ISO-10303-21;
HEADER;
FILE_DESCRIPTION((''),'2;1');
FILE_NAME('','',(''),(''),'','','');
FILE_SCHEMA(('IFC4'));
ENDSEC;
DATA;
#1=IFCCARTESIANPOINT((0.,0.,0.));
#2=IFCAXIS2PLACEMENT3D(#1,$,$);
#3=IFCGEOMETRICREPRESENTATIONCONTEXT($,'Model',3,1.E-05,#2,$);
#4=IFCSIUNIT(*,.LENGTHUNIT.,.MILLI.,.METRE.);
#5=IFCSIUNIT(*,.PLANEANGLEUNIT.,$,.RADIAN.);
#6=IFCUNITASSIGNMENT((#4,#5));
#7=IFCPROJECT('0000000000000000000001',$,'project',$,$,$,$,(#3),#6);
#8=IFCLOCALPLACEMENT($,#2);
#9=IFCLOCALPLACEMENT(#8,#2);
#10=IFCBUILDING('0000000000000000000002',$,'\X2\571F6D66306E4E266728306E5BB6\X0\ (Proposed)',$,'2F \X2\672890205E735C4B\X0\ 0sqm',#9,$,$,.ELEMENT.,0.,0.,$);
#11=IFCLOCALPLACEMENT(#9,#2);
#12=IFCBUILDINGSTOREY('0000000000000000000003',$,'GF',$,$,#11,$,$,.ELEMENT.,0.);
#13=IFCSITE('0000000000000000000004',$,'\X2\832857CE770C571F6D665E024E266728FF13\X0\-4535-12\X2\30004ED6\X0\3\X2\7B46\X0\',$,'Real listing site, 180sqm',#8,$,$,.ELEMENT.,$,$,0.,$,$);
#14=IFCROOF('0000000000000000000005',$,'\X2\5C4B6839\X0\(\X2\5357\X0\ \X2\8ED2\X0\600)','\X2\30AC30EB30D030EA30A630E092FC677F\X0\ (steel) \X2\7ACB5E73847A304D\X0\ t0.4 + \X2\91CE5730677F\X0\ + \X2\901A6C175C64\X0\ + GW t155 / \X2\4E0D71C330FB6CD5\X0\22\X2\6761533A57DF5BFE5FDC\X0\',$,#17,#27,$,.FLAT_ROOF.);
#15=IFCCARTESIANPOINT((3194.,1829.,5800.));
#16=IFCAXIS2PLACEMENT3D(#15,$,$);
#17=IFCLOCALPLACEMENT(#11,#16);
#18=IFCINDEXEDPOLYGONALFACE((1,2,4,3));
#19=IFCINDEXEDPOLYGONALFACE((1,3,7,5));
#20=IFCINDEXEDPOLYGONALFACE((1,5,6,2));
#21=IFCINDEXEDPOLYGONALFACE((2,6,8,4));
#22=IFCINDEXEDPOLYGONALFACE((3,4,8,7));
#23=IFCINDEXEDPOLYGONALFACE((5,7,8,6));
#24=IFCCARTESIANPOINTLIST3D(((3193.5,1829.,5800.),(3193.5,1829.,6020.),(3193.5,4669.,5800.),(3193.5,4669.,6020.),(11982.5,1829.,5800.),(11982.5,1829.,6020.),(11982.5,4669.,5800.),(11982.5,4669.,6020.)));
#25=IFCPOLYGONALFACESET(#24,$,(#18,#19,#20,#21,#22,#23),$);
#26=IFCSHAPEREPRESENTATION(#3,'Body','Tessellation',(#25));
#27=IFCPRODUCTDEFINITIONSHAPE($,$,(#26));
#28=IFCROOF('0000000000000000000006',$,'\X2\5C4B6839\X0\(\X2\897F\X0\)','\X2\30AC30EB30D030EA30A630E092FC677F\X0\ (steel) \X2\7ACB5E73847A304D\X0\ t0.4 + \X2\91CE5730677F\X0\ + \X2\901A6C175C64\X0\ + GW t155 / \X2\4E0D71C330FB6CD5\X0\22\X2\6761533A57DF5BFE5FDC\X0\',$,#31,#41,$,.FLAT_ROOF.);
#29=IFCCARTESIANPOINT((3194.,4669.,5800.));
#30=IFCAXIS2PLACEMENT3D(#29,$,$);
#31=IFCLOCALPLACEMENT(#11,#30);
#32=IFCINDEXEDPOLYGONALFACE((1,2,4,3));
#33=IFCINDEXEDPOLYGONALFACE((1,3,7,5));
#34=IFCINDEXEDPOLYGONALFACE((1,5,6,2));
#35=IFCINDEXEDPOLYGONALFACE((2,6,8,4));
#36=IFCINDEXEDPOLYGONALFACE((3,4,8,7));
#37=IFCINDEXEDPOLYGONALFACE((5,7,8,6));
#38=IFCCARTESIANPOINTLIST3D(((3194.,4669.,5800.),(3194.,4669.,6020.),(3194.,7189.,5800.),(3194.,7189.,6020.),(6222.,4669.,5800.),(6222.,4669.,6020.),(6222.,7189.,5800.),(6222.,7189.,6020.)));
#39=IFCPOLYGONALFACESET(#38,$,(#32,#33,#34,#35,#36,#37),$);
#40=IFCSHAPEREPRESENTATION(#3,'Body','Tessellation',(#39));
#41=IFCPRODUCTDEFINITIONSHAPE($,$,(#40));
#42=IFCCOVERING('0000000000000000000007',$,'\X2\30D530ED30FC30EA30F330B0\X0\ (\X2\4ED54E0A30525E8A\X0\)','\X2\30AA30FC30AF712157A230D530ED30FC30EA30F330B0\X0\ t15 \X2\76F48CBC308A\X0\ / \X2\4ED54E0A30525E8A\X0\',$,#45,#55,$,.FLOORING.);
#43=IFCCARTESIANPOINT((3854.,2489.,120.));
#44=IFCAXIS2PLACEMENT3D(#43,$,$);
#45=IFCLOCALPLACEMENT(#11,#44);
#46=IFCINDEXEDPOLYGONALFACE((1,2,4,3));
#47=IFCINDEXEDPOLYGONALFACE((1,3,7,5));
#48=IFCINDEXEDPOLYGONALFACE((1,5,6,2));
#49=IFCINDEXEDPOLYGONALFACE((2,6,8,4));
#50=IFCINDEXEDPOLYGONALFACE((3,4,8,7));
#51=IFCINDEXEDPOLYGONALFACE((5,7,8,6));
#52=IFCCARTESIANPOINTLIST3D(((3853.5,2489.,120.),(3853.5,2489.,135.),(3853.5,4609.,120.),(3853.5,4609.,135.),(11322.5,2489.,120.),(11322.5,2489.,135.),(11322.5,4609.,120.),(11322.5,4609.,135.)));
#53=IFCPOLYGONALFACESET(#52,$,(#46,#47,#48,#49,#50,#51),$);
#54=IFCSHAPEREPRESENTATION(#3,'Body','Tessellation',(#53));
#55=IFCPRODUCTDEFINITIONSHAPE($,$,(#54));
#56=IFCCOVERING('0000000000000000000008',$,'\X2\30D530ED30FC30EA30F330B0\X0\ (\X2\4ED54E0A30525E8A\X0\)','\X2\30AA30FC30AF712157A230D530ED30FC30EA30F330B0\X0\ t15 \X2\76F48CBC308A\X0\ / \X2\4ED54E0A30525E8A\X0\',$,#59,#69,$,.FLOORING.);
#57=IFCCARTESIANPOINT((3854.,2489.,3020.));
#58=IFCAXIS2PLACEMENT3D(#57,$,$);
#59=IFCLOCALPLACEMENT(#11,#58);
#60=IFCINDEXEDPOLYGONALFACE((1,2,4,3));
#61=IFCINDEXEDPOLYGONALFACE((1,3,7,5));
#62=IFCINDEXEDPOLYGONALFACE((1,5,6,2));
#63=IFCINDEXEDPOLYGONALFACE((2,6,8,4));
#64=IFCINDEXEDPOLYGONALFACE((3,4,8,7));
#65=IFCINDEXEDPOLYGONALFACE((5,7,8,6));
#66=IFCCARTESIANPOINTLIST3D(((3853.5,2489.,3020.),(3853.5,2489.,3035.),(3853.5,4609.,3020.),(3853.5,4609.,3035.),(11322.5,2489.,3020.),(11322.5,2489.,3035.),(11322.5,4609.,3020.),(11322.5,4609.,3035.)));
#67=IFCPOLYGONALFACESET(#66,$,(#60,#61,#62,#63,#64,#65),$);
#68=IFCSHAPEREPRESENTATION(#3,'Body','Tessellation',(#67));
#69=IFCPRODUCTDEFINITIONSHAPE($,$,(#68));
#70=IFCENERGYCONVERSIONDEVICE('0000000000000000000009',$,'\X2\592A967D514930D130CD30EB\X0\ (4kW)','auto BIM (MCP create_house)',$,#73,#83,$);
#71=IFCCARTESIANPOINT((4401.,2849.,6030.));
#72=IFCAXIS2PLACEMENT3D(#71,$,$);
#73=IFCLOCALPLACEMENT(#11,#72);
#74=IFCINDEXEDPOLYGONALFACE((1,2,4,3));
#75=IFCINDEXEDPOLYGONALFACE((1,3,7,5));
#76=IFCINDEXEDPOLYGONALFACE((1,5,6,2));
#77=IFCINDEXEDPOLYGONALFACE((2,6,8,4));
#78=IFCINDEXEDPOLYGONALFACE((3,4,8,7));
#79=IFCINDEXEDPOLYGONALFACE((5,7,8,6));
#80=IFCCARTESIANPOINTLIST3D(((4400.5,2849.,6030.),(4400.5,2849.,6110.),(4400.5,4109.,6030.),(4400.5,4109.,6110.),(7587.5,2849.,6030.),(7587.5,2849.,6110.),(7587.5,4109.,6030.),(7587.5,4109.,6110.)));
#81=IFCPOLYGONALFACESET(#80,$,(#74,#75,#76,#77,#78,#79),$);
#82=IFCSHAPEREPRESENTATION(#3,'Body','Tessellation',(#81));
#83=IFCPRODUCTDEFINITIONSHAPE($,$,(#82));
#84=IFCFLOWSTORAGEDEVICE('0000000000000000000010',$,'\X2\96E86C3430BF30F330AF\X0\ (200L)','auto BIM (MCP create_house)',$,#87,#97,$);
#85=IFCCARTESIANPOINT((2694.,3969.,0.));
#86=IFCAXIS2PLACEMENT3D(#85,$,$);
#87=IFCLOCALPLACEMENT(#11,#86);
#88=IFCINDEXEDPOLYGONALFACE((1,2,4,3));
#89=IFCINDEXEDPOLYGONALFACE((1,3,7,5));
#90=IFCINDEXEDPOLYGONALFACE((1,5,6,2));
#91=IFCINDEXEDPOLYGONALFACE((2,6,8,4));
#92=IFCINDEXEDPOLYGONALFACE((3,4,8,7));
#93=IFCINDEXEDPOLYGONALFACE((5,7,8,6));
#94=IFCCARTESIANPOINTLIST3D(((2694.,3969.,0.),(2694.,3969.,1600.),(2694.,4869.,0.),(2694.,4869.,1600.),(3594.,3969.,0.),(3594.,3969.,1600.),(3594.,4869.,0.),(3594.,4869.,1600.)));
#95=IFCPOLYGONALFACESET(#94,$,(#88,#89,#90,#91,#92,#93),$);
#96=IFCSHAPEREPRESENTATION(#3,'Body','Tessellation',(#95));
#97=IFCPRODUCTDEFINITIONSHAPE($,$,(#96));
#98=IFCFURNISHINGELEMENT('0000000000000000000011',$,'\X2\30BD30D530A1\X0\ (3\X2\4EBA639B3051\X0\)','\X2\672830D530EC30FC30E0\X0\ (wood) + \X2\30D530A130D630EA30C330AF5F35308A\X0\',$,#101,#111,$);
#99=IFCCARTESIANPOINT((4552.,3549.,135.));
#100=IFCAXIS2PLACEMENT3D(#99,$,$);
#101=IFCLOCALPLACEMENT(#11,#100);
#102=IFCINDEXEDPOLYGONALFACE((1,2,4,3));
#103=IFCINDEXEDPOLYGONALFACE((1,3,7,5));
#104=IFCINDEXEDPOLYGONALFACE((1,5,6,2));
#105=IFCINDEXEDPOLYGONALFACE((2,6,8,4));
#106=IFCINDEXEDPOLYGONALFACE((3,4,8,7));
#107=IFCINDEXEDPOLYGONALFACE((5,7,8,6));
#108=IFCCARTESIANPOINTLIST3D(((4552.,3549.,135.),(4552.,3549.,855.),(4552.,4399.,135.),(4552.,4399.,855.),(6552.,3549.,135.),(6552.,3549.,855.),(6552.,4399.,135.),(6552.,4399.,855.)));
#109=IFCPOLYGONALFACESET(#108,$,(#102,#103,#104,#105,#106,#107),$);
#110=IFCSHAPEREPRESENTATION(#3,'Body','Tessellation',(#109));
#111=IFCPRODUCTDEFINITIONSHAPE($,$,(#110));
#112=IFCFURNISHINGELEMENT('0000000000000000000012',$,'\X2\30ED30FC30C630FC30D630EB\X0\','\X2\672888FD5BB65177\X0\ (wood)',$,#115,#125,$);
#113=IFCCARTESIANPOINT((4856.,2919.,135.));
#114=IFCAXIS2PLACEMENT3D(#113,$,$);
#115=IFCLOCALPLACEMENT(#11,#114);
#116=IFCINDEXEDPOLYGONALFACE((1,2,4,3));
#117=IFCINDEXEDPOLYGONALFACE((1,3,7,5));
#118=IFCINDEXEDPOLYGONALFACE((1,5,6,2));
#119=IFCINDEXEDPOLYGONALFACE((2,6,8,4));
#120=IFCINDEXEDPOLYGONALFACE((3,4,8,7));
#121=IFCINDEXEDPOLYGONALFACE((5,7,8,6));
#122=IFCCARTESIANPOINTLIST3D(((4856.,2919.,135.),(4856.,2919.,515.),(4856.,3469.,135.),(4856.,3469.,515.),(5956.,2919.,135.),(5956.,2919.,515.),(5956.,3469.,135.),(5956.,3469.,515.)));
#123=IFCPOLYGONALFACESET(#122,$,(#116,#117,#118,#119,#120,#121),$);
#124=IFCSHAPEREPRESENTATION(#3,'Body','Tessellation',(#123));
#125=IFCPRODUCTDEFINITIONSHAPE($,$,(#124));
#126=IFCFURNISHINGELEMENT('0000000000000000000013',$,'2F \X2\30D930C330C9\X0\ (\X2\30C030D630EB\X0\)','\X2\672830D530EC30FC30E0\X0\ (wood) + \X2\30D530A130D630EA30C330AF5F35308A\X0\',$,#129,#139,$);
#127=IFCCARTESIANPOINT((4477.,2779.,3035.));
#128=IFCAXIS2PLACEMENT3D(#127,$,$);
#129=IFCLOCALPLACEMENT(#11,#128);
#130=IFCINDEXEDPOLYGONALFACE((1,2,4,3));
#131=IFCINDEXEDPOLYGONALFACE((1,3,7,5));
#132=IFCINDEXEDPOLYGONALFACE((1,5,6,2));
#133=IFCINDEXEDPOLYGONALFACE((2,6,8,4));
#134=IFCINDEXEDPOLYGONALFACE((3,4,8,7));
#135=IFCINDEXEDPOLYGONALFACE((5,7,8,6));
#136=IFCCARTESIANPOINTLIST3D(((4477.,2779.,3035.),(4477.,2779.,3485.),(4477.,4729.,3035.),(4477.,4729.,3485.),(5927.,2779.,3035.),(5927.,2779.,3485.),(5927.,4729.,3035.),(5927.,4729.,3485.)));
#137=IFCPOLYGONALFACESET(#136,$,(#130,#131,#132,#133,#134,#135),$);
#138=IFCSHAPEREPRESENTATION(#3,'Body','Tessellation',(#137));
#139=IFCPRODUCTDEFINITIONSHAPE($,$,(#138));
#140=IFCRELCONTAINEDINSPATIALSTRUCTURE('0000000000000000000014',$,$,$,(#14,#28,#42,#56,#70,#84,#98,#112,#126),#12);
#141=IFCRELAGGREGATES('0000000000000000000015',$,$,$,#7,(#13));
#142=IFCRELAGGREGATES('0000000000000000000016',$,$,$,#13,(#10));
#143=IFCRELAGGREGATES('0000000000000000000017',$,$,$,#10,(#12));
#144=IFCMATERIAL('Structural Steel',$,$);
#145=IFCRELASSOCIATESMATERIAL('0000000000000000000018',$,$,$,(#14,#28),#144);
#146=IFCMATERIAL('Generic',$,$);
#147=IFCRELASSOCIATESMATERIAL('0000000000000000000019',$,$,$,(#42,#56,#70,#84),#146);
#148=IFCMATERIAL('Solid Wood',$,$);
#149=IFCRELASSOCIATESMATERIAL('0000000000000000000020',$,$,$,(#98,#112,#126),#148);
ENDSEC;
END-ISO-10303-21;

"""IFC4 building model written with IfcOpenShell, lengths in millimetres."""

from ifc_helpers import new_model, si_unit, frame, frame_2d, origin, place, context, project, spatial, rectangle, extrude, material, element, save


model = new_model("IFC4")

# Units and contexts
model_context = context("Model", 3, precision=1e-05, world=origin())
ifc_project = project(units=[si_unit("LENGTHUNIT", "METRE", prefix="MILLI"), si_unit("PLANEANGLEUNIT", "RADIAN")], contexts=[model_context])

# Site, building, storey
site_placement = place(None, origin())
site = spatial("IfcSite", under=ifc_project, at=site_placement, Name="茨城県土浦市並木３-4535-12　他3筆", ObjectType="Real listing site, 180sqm", CompositionType="ELEMENT", RefElevation=0.0)
building_placement = place(site_placement, origin())
building = spatial("IfcBuilding", under=site, at=building_placement, Name="土浦の並木の家 (Proposed)", ObjectType="2F 木造平屋 0sqm", CompositionType="ELEMENT", ElevationOfRefHeight=0.0, ElevationOfTerrain=0.0)
storey_placement = place(building_placement, origin())
storey = spatial("IfcBuildingStorey", under=building, at=storey_placement, Name="GF", CompositionType="ELEMENT", Elevation=0.0)

# Shared definitions
ifc_material_1 = material(Name="Solid Wood")

# Roofs
ifc_material_2 = material(Name="Structural Steel")
roof_1_placement = place(storey_placement, frame((3194.0, 1829.0, 5800.0)))
element("IfcRoof", 1, at=roof_1_placement, inside=storey, material=ifc_material_2, Name="屋根(南 軒600)", Description="ガルバリウム鋼板 (steel) 立平葺き t0.4 + 野地板 + 通気層 + GW t155 / 不燃・法22条区域対応", PredefinedType="FLAT_ROOF", context=model_context, shape_type="SweptSolid", body=[
    extrude(rectangle(XDim=8789.0, YDim=2840.0, at=frame_2d((4394.0, 1420.0))), frame((3194.0, 1829.0, 5800.0)), (0.0, 0.0, 1.0), 220.0),
])
roof_2_placement = place(storey_placement, frame((3194.0, 4669.0, 5800.0)))
element("IfcRoof", 2, at=roof_2_placement, inside=storey, material=ifc_material_2, Name="屋根(西)", Description="ガルバリウム鋼板 (steel) 立平葺き t0.4 + 野地板 + 通気層 + GW t155 / 不燃・法22条区域対応", PredefinedType="FLAT_ROOF", context=model_context, shape_type="SweptSolid", body=[
    extrude(rectangle(XDim=3028.0, YDim=2520.0, at=frame_2d((1514.0, 1260.0))), frame((3194.0, 4669.0, 5800.0)), (0.0, 0.0, 1.0), 220.0),
])

# Coverings
ifc_material_3 = material(Name="Generic")
covering_1_placement = place(storey_placement, frame((3854.0, 2489.0, 120.0)))
element("IfcCovering", 3, at=covering_1_placement, inside=storey, material=ifc_material_3, Name="フローリング (仕上げ床)", Description="オーク無垢フローリング t15 直貼り / 仕上げ床", PredefinedType="FLOORING", context=model_context, shape_type="SweptSolid", body=[
    extrude(rectangle(XDim=7469.0, YDim=2120.0, at=frame_2d((3734.0, 1060.0))), frame((3854.0, 2489.0, 120.0)), (0.0, 0.0, 1.0), 15.0),
])
covering_2_placement = place(storey_placement, frame((3854.0, 2489.0, 3020.0)))
element("IfcCovering", 4, at=covering_2_placement, inside=storey, material=ifc_material_3, Name="フローリング (仕上げ床)", Description="オーク無垢フローリング t15 直貼り / 仕上げ床", PredefinedType="FLOORING", context=model_context, shape_type="SweptSolid", body=[
    extrude(rectangle(XDim=7469.0, YDim=2120.0, at=frame_2d((3734.0, 1060.0))), frame((3854.0, 2489.0, 3020.0)), (0.0, 0.0, 1.0), 15.0),
])

# Energy conversion device
energy_conversion_device_placement = place(storey_placement, frame((4401.0, 2849.0, 6030.0)))
element("IfcEnergyConversionDevice", 5, at=energy_conversion_device_placement, inside=storey, material=ifc_material_3, Name="太陽光パネル (4kW)", Description="auto BIM (MCP create_house)", context=model_context, shape_type="SweptSolid", body=[
    extrude(rectangle(XDim=3187.0, YDim=1260.0, at=frame_2d((1593.0, 630.0))), frame((4401.0, 2849.0, 6030.0)), (0.0, 0.0, 1.0), 80.0),
])

# Flow storage device
flow_storage_device_placement = place(storey_placement, frame((2694.0, 3969.0, 0.0)))
element("IfcFlowStorageDevice", 6, at=flow_storage_device_placement, inside=storey, material=ifc_material_3, Name="雨水タンク (200L)", Description="auto BIM (MCP create_house)", context=model_context, shape_type="SweptSolid", body=[
    extrude(rectangle(XDim=900.0, YDim=900.0, at=frame_2d((450.0, 450.0))), frame((2694.0, 3969.0, 0.0)), (0.0, 0.0, 1.0), 1600.0),
])

# Furnishing elements
furnishing_1_placement = place(storey_placement, frame((4552.0, 3549.0, 135.0)))
element("IfcFurnishingElement", 7, at=furnishing_1_placement, inside=storey, material=ifc_material_1, Name="ソファ (3人掛け)", Description="木フレーム (wood) + ファブリック張り", context=model_context, shape_type="SweptSolid", body=[
    extrude(rectangle(XDim=2000.0, YDim=850.0, at=frame_2d((1000.0, 425.0))), frame((4552.0, 3549.0, 135.0)), (0.0, 0.0, 1.0), 720.0),
])
furnishing_2_placement = place(storey_placement, frame((4856.0, 2919.0, 135.0)))
element("IfcFurnishingElement", 8, at=furnishing_2_placement, inside=storey, material=ifc_material_1, Name="ローテーブル", Description="木製家具 (wood)", context=model_context, shape_type="SweptSolid", body=[
    extrude(rectangle(XDim=1100.0, YDim=550.0, at=frame_2d((550.0, 275.0))), frame((4856.0, 2919.0, 135.0)), (0.0, 0.0, 1.0), 380.0),
])
furnishing_3_placement = place(storey_placement, frame((4477.0, 2779.0, 3035.0)))
element("IfcFurnishingElement", 9, at=furnishing_3_placement, inside=storey, material=ifc_material_1, Name="2F ベッド (ダブル)", Description="木フレーム (wood) + ファブリック張り", context=model_context, shape_type="SweptSolid", body=[
    extrude(rectangle(XDim=1450.0, YDim=1950.0, at=frame_2d((725.0, 975.0))), frame((4477.0, 2779.0, 3035.0)), (0.0, 0.0, 1.0), 450.0),
])

save(model, "model.ifc")
